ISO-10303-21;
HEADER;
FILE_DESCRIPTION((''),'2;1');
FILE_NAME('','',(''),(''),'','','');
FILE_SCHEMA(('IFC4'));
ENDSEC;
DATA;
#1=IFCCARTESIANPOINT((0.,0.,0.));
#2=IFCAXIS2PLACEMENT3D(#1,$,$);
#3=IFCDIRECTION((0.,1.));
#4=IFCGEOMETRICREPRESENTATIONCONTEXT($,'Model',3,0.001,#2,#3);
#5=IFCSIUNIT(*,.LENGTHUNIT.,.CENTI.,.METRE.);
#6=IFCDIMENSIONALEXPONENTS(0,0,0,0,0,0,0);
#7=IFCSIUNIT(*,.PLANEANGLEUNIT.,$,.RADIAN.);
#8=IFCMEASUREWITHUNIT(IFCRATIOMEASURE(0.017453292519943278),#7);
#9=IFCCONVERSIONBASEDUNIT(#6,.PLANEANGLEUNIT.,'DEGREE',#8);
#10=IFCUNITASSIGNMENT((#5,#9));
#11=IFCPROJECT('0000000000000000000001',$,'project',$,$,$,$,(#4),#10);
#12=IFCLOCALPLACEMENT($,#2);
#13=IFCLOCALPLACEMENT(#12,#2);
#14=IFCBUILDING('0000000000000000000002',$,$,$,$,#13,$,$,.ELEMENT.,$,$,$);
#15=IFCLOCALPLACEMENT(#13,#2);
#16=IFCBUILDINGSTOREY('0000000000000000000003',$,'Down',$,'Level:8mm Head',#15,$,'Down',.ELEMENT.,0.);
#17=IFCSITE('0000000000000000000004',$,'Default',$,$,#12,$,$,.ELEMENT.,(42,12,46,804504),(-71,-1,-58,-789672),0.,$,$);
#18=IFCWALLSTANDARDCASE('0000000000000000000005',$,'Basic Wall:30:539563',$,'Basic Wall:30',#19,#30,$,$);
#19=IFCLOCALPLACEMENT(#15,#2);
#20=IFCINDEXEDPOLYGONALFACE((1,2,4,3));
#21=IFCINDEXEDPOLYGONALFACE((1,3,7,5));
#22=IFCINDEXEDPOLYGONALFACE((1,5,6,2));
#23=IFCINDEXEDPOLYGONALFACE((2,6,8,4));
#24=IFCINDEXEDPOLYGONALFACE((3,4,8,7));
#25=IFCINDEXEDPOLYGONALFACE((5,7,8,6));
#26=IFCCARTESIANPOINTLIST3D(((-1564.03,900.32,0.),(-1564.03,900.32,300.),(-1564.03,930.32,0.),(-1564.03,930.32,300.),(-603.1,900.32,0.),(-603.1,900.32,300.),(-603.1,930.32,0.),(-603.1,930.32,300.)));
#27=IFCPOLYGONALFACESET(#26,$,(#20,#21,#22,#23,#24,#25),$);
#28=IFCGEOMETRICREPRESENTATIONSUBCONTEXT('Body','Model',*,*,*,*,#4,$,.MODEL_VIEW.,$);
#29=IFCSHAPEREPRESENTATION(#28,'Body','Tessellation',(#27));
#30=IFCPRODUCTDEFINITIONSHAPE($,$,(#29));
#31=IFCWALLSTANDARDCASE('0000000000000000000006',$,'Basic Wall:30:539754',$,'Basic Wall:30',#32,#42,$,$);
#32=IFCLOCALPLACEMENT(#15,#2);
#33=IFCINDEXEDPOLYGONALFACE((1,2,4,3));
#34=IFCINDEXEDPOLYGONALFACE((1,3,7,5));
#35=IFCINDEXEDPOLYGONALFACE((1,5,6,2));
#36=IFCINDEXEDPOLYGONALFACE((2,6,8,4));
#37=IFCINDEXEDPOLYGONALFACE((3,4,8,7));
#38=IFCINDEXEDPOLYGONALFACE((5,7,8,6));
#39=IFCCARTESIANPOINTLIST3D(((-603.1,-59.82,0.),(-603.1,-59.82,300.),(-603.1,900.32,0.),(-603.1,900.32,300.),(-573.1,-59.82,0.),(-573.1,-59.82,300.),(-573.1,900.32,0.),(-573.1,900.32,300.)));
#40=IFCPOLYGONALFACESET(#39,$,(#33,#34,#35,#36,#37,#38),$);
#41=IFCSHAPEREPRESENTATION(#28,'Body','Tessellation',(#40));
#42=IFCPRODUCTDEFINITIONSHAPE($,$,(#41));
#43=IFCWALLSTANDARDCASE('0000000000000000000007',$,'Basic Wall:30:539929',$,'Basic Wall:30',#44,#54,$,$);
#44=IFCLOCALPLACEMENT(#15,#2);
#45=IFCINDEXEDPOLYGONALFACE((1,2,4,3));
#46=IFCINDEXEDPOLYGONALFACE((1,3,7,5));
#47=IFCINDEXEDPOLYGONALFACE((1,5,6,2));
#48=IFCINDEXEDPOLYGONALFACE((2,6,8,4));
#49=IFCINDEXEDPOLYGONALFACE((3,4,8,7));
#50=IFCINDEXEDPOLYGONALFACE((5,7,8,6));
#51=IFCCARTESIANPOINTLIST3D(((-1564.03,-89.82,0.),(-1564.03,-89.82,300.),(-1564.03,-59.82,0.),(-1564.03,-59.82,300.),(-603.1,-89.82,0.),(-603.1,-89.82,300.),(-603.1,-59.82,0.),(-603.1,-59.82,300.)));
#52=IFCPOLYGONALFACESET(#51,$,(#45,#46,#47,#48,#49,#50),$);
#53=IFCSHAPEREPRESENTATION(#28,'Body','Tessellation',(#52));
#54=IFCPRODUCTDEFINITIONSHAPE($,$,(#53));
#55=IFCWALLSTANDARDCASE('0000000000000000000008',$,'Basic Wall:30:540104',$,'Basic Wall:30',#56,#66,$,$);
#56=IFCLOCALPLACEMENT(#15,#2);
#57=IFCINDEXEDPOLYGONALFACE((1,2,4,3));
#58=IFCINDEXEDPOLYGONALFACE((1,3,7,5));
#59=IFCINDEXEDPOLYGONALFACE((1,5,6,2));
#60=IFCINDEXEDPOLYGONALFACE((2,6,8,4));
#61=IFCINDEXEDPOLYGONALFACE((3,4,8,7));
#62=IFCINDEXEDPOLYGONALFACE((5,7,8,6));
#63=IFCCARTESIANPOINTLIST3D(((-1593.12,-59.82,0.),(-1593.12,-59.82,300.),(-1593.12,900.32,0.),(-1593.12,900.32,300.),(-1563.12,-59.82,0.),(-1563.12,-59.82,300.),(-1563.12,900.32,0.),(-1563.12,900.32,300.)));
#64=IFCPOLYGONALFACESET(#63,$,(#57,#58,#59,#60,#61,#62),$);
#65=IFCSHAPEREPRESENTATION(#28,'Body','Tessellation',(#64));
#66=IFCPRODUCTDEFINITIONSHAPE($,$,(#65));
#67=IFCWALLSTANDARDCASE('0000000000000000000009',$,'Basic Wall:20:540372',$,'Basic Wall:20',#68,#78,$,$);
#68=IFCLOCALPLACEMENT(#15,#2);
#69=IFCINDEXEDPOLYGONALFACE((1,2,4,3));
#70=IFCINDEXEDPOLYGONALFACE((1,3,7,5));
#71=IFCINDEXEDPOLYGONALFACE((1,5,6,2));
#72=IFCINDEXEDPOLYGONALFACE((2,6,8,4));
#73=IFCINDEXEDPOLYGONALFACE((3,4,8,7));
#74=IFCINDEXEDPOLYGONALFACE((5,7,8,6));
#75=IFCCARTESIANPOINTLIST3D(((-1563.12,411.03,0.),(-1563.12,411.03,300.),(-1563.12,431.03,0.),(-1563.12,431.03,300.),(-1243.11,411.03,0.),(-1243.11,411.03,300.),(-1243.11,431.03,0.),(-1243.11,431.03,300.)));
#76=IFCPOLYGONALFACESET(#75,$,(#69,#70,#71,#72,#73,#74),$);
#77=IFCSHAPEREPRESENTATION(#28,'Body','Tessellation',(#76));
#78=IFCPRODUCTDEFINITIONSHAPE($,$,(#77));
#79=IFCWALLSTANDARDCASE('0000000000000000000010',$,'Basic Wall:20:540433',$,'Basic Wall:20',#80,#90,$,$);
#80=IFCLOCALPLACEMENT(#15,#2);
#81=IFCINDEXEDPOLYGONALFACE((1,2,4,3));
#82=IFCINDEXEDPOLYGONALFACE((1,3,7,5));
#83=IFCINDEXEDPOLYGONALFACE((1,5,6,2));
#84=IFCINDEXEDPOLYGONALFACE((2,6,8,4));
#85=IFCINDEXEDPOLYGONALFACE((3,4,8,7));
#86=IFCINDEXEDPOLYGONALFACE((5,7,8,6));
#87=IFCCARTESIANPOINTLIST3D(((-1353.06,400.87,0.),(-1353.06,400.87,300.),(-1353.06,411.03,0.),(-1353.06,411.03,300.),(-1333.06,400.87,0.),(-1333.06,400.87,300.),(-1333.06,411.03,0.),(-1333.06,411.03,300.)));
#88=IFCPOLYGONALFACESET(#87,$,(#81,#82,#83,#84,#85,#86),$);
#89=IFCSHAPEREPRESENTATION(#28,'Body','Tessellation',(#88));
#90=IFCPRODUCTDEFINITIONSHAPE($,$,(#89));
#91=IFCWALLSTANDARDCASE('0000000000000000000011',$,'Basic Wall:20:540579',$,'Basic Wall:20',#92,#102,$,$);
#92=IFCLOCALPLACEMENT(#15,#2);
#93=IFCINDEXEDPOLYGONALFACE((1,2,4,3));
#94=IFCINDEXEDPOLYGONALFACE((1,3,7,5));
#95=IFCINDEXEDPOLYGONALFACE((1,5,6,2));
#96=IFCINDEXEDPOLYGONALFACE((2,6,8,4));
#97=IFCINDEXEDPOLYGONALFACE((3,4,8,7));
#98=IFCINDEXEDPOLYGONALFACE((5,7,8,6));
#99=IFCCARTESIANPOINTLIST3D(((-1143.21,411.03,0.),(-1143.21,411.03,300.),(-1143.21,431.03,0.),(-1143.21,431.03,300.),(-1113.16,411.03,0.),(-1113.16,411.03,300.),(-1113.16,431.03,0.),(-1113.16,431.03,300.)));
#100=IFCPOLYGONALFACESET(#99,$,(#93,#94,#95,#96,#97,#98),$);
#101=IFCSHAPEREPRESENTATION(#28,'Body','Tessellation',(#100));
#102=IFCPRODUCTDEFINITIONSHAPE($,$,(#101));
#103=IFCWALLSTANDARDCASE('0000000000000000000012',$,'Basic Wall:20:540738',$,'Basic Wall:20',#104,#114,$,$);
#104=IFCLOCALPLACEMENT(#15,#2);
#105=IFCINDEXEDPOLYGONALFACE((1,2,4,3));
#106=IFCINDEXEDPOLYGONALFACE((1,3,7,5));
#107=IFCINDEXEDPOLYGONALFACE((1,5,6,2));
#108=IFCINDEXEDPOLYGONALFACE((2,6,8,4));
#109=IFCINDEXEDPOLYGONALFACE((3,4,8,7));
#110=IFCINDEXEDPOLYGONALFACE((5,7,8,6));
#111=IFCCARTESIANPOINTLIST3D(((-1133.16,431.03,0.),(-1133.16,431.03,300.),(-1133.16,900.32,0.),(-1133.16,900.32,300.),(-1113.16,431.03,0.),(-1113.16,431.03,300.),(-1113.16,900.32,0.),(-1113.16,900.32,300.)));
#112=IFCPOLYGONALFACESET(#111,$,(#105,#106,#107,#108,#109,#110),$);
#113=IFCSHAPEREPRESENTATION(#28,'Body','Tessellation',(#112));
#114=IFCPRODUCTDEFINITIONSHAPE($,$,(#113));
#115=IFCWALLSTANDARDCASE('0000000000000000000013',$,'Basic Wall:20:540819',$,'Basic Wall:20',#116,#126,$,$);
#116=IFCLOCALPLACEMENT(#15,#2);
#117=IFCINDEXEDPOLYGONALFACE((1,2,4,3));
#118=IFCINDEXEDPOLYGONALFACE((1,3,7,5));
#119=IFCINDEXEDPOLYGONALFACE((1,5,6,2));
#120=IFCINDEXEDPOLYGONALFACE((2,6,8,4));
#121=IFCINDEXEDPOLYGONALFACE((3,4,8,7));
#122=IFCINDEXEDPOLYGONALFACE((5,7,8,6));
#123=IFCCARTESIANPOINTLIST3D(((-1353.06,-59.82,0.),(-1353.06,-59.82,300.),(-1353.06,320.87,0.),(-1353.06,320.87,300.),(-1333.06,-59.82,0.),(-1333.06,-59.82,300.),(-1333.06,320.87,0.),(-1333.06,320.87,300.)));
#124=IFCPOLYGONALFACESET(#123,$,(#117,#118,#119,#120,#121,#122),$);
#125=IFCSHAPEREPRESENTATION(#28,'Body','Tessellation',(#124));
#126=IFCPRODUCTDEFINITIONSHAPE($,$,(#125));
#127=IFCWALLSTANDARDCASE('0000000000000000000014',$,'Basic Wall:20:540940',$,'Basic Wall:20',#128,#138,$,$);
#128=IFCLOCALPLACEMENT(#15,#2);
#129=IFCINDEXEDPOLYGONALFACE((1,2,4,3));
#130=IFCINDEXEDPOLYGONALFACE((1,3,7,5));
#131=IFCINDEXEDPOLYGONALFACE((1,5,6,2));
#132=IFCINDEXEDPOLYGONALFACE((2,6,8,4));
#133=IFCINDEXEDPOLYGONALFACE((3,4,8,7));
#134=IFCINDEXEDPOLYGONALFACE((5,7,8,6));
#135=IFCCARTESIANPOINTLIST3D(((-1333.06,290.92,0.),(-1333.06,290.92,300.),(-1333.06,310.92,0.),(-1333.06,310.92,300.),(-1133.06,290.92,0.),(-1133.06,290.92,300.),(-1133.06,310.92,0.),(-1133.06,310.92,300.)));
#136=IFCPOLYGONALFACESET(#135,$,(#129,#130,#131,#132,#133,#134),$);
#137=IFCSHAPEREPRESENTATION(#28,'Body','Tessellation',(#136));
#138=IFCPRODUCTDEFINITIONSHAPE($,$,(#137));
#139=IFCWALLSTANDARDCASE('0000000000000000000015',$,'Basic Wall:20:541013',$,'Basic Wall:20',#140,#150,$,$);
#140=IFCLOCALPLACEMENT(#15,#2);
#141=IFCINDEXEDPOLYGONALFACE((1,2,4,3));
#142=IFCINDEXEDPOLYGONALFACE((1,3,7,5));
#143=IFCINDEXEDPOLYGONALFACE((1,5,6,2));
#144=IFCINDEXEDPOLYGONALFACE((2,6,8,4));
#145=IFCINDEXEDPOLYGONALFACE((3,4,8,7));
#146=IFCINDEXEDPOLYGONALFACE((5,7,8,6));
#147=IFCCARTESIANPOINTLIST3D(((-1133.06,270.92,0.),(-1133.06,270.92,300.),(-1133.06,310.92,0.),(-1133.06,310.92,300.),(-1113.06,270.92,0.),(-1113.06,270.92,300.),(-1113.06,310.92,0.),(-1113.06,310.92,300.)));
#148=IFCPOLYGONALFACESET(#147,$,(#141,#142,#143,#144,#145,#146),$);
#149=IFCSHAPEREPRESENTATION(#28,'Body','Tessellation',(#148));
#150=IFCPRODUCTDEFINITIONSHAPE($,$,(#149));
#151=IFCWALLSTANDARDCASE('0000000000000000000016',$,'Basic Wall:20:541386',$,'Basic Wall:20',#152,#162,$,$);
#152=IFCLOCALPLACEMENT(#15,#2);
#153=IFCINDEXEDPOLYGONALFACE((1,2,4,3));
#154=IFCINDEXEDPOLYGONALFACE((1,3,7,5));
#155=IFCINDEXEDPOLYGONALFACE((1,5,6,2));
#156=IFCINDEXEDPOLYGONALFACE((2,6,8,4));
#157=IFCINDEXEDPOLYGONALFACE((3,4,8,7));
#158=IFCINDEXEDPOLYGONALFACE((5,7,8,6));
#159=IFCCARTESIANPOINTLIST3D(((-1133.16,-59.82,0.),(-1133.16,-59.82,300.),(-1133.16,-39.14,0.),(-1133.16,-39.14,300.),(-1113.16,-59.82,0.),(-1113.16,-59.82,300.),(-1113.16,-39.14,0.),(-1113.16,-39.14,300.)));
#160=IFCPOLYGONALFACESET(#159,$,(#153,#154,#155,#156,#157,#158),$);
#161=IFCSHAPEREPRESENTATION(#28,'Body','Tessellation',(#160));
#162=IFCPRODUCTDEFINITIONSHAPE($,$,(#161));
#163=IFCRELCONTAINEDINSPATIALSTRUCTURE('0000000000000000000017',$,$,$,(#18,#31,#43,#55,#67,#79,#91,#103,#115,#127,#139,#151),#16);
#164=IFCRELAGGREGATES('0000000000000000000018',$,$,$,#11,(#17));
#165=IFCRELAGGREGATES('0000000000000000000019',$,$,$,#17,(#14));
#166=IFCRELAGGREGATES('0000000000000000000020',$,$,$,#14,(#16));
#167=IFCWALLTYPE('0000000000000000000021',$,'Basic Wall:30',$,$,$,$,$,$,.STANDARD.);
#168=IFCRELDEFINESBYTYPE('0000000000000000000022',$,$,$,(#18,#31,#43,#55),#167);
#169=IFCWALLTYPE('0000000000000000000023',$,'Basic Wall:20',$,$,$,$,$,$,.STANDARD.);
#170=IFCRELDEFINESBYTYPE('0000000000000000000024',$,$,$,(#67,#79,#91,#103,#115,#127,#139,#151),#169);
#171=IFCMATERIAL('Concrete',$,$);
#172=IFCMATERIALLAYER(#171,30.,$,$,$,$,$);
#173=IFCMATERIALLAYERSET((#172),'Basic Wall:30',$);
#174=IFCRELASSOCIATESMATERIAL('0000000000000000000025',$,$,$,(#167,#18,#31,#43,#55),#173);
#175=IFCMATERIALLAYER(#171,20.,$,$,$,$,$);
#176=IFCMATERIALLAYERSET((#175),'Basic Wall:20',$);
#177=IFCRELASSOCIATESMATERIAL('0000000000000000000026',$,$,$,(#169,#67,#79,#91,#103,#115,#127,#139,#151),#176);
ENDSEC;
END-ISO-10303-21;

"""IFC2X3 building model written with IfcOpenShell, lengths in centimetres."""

from ifc_helpers import new_model, entity, si_unit, converted_unit, direction, frame, frame_2d, origin, place, context, subcontext, project, spatial, polyline, rectangle, extrude, clip, bounded_halfspace, material, layer, layer_set, layer_usage, type_object, element, save


model = new_model("IFC2X3")

# Units and contexts
model_context = context("Model", 3, precision=0.001, world=origin(), true_north=direction((0.0, 1.0)))
body_context = subcontext(model_context, "Body", "Model", "MODEL_VIEW")
ifc_project = project(units=[si_unit("LENGTHUNIT", "METRE", prefix="CENTI"), converted_unit("PLANEANGLEUNIT", "DEGREE", entity("IfcRatioMeasure", 0.017453292519943278), si_unit("PLANEANGLEUNIT", "RADIAN"), dimensions=[0, 0, 0, 0, 0, 0, 0])], contexts=[model_context])

# Site, building, storey
site_placement = place(None, origin())
site = spatial("IfcSite", under=ifc_project, at=site_placement, Name="Default", CompositionType="ELEMENT", RefLatitude=(42, 12, 46, 804504), RefLongitude=(-71, -1, -58, -789672), RefElevation=0.0)
building_placement = place(site_placement, origin())
building = spatial("IfcBuilding", under=site, at=building_placement, CompositionType="ELEMENT")
storey_placement = place(building_placement, origin())
storey = spatial("IfcBuildingStorey", under=building, at=storey_placement, Name="Down", ObjectType="Level:8mm Head", LongName="Down", CompositionType="ELEMENT", Elevation=0.0)

# Shared definitions
ifc_material = material(Name="Concrete")

# Walls
ifc_layer_1 = layer(ifc_material, 30.0)
ifc_layer_set_1 = layer_set([ifc_layer_1], Name="Basic Wall:30")
ifc_layer_usage_1 = layer_usage(ifc_layer_set_1, "AXIS2", "POSITIVE", -15.0)
wall_type_1 = type_object("IfcWallType", Name="Basic Wall:30", PredefinedType="STANDARD", material=ifc_layer_set_1)
wall_1_placement = place(storey_placement, frame((-1564.03, 915.32, 0.0)))
element("IfcWallStandardCase", 1, at=wall_1_placement, inside=storey, type_object=wall_type_1, material=ifc_layer_usage_1, Name="Basic Wall:30:539563", ObjectType="Basic Wall:30", context=body_context, shape_type="Clipping", body=[
    clip(clip(extrude(rectangle(XDim=960.94, YDim=30.0, at=frame_2d((480.47, 0.0), x_axis=(-1.0, 0.0))), origin(), (0.0, 0.0, 1.0), 300.0), bounded_halfspace(frame((0.0, -15.0, 0.0), z_axis=(1.0, 0.0, 0.0), x_axis=(0.0, 0.0, -1.0)), True, frame((0.0, -15.0, 0.0), z_axis=(1.0, 0.0, 0.0), x_axis=(0.0, 0.0, -1.0)), polyline([(0.0, 0.0), (0.0, 30.0), (-210.0, 30.0), (-300.0, 30.0), (-300.0, 0.0), (0.0, 0.0)]))), bounded_halfspace(frame((960.94, -15.0, 300.0), z_axis=(-1.0, 0.0, 0.0), x_axis=(0.0, 0.0, -1.0)), True, frame((960.94, -15.0, 300.0), z_axis=(-1.0, 0.0, 0.0), x_axis=(0.0, 0.0, -1.0)), polyline([(0.0, 0.0), (0.0, -30.0), (90.0, -30.0), (300.0, -30.0), (300.0, 0.0), (25.0, 0.0), (0.0, 0.0)]))),
])
ifc_layer_usage_2 = layer_usage(ifc_layer_set_1, "AXIS2", "POSITIVE", -15.0)
wall_2_placement = place(storey_placement, frame((-588.1, 900.32, 0.0), z_axis=(0.0, 0.0, 1.0), x_axis=(0.0, -1.0, 0.0)))
element("IfcWallStandardCase", 2, at=wall_2_placement, inside=storey, type_object=wall_type_1, material=ifc_layer_usage_2, Name="Basic Wall:30:539754", ObjectType="Basic Wall:30", context=body_context, shape_type="Clipping", body=[
    clip(extrude(rectangle(XDim=960.14, YDim=30.0, at=frame_2d((480.07, 0.0), x_axis=(-1.0, 0.0))), origin(), (0.0, 0.0, 1.0), 300.0), bounded_halfspace(frame((960.14, -15.0, 300.0), z_axis=(-1.0, 0.0, 0.0), x_axis=(0.0, 0.0, -1.0)), True, frame((960.14, -15.0, 300.0), z_axis=(-1.0, 0.0, 0.0), x_axis=(0.0, 0.0, -1.0)), polyline([(0.0, 0.0), (0.0, -30.0), (90.0, -30.0), (300.0, -30.0), (300.0, 0.0), (25.0, 0.0), (0.0, 0.0)]))),
])
ifc_layer_usage_3 = layer_usage(ifc_layer_set_1, "AXIS2", "POSITIVE", -15.0)
wall_3_placement = place(storey_placement, frame((-603.1, -74.82, 0.0), z_axis=(0.0, 0.0, 1.0), x_axis=(-1.0, 0.0, 0.0)))
element("IfcWallStandardCase", 3, at=wall_3_placement, inside=storey, type_object=wall_type_1, material=ifc_layer_usage_3, Name="Basic Wall:30:539929", ObjectType="Basic Wall:30", context=body_context, shape_type="Clipping", body=[
    clip(extrude(rectangle(XDim=960.94, YDim=30.0, at=frame_2d((480.47, 0.0), x_axis=(-1.0, 0.0))), origin(), (0.0, 0.0, 1.0), 300.0), bounded_halfspace(frame((960.94, -15.0, 300.0), z_axis=(-1.0, 0.0, 0.0), x_axis=(0.0, 0.0, -1.0)), True, frame((960.94, -15.0, 300.0), z_axis=(-1.0, 0.0, 0.0), x_axis=(0.0, 0.0, -1.0)), polyline([(0.0, 0.0), (0.0, -30.0), (90.0, -30.0), (300.0, -30.0), (300.0, 0.0), (0.0, 0.0)]))),
])
ifc_layer_usage_4 = layer_usage(ifc_layer_set_1, "AXIS2", "POSITIVE", -15.0)
wall_4_placement = place(storey_placement, frame((-1578.12, -59.82, 0.0), z_axis=(0.0, 0.0, 1.0), x_axis=(0.0, 1.0, 0.0)))
element("IfcWallStandardCase", 4, at=wall_4_placement, inside=storey, type_object=wall_type_1, material=ifc_layer_usage_4, Name="Basic Wall:30:540104", ObjectType="Basic Wall:30", context=body_context, shape_type="SweptSolid", body=[
    extrude(rectangle(XDim=960.14, YDim=30.0, at=frame_2d((480.07, 0.0), x_axis=(-1.0, 0.0))), origin(), (0.0, 0.0, 1.0), 300.0),
])
ifc_layer_2 = layer(ifc_material, 20.0)
ifc_layer_set_2 = layer_set([ifc_layer_2], Name="Basic Wall:20")
ifc_layer_usage_5 = layer_usage(ifc_layer_set_2, "AXIS2", "POSITIVE", -10.0)
wall_type_2 = type_object("IfcWallType", Name="Basic Wall:20", PredefinedType="STANDARD", material=ifc_layer_set_2)
wall_5_placement = place(storey_placement, frame((-1563.12, 421.03, 0.0)))
element("IfcWallStandardCase", 5, at=wall_5_placement, inside=storey, type_object=wall_type_2, material=ifc_layer_usage_5, Name="Basic Wall:20:540372", ObjectType="Basic Wall:20", context=body_context, shape_type="SweptSolid", body=[
    extrude(rectangle(XDim=320.01, YDim=20.0, at=frame_2d((160.01, 0.0), x_axis=(-1.0, 0.0))), origin(), (0.0, 0.0, 1.0), 300.0),
])
ifc_layer_usage_6 = layer_usage(ifc_layer_set_2, "AXIS2", "NEGATIVE", 10.0)
wall_6_placement = place(storey_placement, frame((-1343.06, 411.03, 0.0), z_axis=(0.0, 0.0, 1.0), x_axis=(0.0, -1.0, 0.0)))
element("IfcWallStandardCase", 6, at=wall_6_placement, inside=storey, type_object=wall_type_2, material=ifc_layer_usage_6, Name="Basic Wall:20:540433", ObjectType="Basic Wall:20", context=body_context, shape_type="SweptSolid", body=[
    extrude(rectangle(XDim=10.16, YDim=20.0, at=frame_2d((5.08, 0.0), x_axis=(-1.0, 0.0))), origin(), (0.0, 0.0, 1.0), 300.0),
])
ifc_layer_usage_7 = layer_usage(ifc_layer_set_2, "AXIS2", "POSITIVE", -10.0)
wall_7_placement = place(storey_placement, frame((-1143.21, 421.03, 0.0)))
element("IfcWallStandardCase", 7, at=wall_7_placement, inside=storey, type_object=wall_type_2, material=ifc_layer_usage_7, Name="Basic Wall:20:540579", ObjectType="Basic Wall:20", context=body_context, shape_type="SweptSolid", body=[
    extrude(rectangle(XDim=30.05, YDim=20.0, at=frame_2d((15.03, 0.0), x_axis=(-1.0, 0.0))), origin(), (0.0, 0.0, 1.0), 300.0),
])
ifc_layer_usage_8 = layer_usage(ifc_layer_set_2, "AXIS2", "POSITIVE", -10.0)
wall_8_placement = place(storey_placement, frame((-1123.16, 431.03, 0.0), z_axis=(0.0, 0.0, 1.0), x_axis=(0.0, 1.0, 0.0)))
element("IfcWallStandardCase", 8, at=wall_8_placement, inside=storey, type_object=wall_type_2, material=ifc_layer_usage_8, Name="Basic Wall:20:540738", ObjectType="Basic Wall:20", context=body_context, shape_type="SweptSolid", body=[
    extrude(rectangle(XDim=469.28, YDim=20.0, at=frame_2d((234.64, 0.0), x_axis=(-1.0, 0.0))), origin(), (0.0, 0.0, 1.0), 300.0),
])
ifc_layer_usage_9 = layer_usage(ifc_layer_set_2, "AXIS2", "NEGATIVE", 10.0)
wall_9_placement = place(storey_placement, frame((-1343.06, 320.87, 0.0), z_axis=(0.0, 0.0, 1.0), x_axis=(0.0, -1.0, 0.0)))
element("IfcWallStandardCase", 9, at=wall_9_placement, inside=storey, type_object=wall_type_2, material=ifc_layer_usage_9, Name="Basic Wall:20:540819", ObjectType="Basic Wall:20", context=body_context, shape_type="SweptSolid", body=[
    extrude(rectangle(XDim=380.7, YDim=20.0, at=frame_2d((190.35, 0.0), x_axis=(-1.0, 0.0))), origin(), (0.0, 0.0, 1.0), 300.0),
])
ifc_layer_usage_10 = layer_usage(ifc_layer_set_2, "AXIS2", "NEGATIVE", 10.0)
wall_10_placement = place(storey_placement, frame((-1333.06, 300.92, 0.0)))
element("IfcWallStandardCase", 10, at=wall_10_placement, inside=storey, type_object=wall_type_2, material=ifc_layer_usage_10, Name="Basic Wall:20:540940", ObjectType="Basic Wall:20", context=body_context, shape_type="SweptSolid", body=[
    extrude(rectangle(XDim=200.0, YDim=20.0, at=frame_2d((100.0, 0.0), x_axis=(-1.0, 0.0))), origin(), (0.0, 0.0, 1.0), 300.0),
])
ifc_layer_usage_11 = layer_usage(ifc_layer_set_2, "AXIS2", "NEGATIVE", 10.0)
wall_11_placement = place(storey_placement, frame((-1123.06, 310.92, 0.0), z_axis=(0.0, 0.0, 1.0), x_axis=(0.0, -1.0, 0.0)))
element("IfcWallStandardCase", 11, at=wall_11_placement, inside=storey, type_object=wall_type_2, material=ifc_layer_usage_11, Name="Basic Wall:20:541013", ObjectType="Basic Wall:20", context=body_context, shape_type="SweptSolid", body=[
    extrude(rectangle(XDim=40.0, YDim=20.0, at=frame_2d((20.0, 0.0), x_axis=(-1.0, 0.0))), origin(), (0.0, 0.0, 1.0), 300.0),
])
ifc_layer_usage_12 = layer_usage(ifc_layer_set_2, "AXIS2", "NEGATIVE", 10.0)
wall_12_placement = place(storey_placement, frame((-1123.16, -59.82, 0.0), z_axis=(0.0, 0.0, 1.0), x_axis=(0.0, 1.0, 0.0)))
element("IfcWallStandardCase", 12, at=wall_12_placement, inside=storey, type_object=wall_type_2, material=ifc_layer_usage_12, Name="Basic Wall:20:541386", ObjectType="Basic Wall:20", context=body_context, shape_type="SweptSolid", body=[
    extrude(rectangle(XDim=20.68, YDim=20.0, at=frame_2d((10.34, 0.0), x_axis=(-1.0, 0.0))), origin(), (0.0, 0.0, 1.0), 300.0),
])

save(model, "model.ifc")
